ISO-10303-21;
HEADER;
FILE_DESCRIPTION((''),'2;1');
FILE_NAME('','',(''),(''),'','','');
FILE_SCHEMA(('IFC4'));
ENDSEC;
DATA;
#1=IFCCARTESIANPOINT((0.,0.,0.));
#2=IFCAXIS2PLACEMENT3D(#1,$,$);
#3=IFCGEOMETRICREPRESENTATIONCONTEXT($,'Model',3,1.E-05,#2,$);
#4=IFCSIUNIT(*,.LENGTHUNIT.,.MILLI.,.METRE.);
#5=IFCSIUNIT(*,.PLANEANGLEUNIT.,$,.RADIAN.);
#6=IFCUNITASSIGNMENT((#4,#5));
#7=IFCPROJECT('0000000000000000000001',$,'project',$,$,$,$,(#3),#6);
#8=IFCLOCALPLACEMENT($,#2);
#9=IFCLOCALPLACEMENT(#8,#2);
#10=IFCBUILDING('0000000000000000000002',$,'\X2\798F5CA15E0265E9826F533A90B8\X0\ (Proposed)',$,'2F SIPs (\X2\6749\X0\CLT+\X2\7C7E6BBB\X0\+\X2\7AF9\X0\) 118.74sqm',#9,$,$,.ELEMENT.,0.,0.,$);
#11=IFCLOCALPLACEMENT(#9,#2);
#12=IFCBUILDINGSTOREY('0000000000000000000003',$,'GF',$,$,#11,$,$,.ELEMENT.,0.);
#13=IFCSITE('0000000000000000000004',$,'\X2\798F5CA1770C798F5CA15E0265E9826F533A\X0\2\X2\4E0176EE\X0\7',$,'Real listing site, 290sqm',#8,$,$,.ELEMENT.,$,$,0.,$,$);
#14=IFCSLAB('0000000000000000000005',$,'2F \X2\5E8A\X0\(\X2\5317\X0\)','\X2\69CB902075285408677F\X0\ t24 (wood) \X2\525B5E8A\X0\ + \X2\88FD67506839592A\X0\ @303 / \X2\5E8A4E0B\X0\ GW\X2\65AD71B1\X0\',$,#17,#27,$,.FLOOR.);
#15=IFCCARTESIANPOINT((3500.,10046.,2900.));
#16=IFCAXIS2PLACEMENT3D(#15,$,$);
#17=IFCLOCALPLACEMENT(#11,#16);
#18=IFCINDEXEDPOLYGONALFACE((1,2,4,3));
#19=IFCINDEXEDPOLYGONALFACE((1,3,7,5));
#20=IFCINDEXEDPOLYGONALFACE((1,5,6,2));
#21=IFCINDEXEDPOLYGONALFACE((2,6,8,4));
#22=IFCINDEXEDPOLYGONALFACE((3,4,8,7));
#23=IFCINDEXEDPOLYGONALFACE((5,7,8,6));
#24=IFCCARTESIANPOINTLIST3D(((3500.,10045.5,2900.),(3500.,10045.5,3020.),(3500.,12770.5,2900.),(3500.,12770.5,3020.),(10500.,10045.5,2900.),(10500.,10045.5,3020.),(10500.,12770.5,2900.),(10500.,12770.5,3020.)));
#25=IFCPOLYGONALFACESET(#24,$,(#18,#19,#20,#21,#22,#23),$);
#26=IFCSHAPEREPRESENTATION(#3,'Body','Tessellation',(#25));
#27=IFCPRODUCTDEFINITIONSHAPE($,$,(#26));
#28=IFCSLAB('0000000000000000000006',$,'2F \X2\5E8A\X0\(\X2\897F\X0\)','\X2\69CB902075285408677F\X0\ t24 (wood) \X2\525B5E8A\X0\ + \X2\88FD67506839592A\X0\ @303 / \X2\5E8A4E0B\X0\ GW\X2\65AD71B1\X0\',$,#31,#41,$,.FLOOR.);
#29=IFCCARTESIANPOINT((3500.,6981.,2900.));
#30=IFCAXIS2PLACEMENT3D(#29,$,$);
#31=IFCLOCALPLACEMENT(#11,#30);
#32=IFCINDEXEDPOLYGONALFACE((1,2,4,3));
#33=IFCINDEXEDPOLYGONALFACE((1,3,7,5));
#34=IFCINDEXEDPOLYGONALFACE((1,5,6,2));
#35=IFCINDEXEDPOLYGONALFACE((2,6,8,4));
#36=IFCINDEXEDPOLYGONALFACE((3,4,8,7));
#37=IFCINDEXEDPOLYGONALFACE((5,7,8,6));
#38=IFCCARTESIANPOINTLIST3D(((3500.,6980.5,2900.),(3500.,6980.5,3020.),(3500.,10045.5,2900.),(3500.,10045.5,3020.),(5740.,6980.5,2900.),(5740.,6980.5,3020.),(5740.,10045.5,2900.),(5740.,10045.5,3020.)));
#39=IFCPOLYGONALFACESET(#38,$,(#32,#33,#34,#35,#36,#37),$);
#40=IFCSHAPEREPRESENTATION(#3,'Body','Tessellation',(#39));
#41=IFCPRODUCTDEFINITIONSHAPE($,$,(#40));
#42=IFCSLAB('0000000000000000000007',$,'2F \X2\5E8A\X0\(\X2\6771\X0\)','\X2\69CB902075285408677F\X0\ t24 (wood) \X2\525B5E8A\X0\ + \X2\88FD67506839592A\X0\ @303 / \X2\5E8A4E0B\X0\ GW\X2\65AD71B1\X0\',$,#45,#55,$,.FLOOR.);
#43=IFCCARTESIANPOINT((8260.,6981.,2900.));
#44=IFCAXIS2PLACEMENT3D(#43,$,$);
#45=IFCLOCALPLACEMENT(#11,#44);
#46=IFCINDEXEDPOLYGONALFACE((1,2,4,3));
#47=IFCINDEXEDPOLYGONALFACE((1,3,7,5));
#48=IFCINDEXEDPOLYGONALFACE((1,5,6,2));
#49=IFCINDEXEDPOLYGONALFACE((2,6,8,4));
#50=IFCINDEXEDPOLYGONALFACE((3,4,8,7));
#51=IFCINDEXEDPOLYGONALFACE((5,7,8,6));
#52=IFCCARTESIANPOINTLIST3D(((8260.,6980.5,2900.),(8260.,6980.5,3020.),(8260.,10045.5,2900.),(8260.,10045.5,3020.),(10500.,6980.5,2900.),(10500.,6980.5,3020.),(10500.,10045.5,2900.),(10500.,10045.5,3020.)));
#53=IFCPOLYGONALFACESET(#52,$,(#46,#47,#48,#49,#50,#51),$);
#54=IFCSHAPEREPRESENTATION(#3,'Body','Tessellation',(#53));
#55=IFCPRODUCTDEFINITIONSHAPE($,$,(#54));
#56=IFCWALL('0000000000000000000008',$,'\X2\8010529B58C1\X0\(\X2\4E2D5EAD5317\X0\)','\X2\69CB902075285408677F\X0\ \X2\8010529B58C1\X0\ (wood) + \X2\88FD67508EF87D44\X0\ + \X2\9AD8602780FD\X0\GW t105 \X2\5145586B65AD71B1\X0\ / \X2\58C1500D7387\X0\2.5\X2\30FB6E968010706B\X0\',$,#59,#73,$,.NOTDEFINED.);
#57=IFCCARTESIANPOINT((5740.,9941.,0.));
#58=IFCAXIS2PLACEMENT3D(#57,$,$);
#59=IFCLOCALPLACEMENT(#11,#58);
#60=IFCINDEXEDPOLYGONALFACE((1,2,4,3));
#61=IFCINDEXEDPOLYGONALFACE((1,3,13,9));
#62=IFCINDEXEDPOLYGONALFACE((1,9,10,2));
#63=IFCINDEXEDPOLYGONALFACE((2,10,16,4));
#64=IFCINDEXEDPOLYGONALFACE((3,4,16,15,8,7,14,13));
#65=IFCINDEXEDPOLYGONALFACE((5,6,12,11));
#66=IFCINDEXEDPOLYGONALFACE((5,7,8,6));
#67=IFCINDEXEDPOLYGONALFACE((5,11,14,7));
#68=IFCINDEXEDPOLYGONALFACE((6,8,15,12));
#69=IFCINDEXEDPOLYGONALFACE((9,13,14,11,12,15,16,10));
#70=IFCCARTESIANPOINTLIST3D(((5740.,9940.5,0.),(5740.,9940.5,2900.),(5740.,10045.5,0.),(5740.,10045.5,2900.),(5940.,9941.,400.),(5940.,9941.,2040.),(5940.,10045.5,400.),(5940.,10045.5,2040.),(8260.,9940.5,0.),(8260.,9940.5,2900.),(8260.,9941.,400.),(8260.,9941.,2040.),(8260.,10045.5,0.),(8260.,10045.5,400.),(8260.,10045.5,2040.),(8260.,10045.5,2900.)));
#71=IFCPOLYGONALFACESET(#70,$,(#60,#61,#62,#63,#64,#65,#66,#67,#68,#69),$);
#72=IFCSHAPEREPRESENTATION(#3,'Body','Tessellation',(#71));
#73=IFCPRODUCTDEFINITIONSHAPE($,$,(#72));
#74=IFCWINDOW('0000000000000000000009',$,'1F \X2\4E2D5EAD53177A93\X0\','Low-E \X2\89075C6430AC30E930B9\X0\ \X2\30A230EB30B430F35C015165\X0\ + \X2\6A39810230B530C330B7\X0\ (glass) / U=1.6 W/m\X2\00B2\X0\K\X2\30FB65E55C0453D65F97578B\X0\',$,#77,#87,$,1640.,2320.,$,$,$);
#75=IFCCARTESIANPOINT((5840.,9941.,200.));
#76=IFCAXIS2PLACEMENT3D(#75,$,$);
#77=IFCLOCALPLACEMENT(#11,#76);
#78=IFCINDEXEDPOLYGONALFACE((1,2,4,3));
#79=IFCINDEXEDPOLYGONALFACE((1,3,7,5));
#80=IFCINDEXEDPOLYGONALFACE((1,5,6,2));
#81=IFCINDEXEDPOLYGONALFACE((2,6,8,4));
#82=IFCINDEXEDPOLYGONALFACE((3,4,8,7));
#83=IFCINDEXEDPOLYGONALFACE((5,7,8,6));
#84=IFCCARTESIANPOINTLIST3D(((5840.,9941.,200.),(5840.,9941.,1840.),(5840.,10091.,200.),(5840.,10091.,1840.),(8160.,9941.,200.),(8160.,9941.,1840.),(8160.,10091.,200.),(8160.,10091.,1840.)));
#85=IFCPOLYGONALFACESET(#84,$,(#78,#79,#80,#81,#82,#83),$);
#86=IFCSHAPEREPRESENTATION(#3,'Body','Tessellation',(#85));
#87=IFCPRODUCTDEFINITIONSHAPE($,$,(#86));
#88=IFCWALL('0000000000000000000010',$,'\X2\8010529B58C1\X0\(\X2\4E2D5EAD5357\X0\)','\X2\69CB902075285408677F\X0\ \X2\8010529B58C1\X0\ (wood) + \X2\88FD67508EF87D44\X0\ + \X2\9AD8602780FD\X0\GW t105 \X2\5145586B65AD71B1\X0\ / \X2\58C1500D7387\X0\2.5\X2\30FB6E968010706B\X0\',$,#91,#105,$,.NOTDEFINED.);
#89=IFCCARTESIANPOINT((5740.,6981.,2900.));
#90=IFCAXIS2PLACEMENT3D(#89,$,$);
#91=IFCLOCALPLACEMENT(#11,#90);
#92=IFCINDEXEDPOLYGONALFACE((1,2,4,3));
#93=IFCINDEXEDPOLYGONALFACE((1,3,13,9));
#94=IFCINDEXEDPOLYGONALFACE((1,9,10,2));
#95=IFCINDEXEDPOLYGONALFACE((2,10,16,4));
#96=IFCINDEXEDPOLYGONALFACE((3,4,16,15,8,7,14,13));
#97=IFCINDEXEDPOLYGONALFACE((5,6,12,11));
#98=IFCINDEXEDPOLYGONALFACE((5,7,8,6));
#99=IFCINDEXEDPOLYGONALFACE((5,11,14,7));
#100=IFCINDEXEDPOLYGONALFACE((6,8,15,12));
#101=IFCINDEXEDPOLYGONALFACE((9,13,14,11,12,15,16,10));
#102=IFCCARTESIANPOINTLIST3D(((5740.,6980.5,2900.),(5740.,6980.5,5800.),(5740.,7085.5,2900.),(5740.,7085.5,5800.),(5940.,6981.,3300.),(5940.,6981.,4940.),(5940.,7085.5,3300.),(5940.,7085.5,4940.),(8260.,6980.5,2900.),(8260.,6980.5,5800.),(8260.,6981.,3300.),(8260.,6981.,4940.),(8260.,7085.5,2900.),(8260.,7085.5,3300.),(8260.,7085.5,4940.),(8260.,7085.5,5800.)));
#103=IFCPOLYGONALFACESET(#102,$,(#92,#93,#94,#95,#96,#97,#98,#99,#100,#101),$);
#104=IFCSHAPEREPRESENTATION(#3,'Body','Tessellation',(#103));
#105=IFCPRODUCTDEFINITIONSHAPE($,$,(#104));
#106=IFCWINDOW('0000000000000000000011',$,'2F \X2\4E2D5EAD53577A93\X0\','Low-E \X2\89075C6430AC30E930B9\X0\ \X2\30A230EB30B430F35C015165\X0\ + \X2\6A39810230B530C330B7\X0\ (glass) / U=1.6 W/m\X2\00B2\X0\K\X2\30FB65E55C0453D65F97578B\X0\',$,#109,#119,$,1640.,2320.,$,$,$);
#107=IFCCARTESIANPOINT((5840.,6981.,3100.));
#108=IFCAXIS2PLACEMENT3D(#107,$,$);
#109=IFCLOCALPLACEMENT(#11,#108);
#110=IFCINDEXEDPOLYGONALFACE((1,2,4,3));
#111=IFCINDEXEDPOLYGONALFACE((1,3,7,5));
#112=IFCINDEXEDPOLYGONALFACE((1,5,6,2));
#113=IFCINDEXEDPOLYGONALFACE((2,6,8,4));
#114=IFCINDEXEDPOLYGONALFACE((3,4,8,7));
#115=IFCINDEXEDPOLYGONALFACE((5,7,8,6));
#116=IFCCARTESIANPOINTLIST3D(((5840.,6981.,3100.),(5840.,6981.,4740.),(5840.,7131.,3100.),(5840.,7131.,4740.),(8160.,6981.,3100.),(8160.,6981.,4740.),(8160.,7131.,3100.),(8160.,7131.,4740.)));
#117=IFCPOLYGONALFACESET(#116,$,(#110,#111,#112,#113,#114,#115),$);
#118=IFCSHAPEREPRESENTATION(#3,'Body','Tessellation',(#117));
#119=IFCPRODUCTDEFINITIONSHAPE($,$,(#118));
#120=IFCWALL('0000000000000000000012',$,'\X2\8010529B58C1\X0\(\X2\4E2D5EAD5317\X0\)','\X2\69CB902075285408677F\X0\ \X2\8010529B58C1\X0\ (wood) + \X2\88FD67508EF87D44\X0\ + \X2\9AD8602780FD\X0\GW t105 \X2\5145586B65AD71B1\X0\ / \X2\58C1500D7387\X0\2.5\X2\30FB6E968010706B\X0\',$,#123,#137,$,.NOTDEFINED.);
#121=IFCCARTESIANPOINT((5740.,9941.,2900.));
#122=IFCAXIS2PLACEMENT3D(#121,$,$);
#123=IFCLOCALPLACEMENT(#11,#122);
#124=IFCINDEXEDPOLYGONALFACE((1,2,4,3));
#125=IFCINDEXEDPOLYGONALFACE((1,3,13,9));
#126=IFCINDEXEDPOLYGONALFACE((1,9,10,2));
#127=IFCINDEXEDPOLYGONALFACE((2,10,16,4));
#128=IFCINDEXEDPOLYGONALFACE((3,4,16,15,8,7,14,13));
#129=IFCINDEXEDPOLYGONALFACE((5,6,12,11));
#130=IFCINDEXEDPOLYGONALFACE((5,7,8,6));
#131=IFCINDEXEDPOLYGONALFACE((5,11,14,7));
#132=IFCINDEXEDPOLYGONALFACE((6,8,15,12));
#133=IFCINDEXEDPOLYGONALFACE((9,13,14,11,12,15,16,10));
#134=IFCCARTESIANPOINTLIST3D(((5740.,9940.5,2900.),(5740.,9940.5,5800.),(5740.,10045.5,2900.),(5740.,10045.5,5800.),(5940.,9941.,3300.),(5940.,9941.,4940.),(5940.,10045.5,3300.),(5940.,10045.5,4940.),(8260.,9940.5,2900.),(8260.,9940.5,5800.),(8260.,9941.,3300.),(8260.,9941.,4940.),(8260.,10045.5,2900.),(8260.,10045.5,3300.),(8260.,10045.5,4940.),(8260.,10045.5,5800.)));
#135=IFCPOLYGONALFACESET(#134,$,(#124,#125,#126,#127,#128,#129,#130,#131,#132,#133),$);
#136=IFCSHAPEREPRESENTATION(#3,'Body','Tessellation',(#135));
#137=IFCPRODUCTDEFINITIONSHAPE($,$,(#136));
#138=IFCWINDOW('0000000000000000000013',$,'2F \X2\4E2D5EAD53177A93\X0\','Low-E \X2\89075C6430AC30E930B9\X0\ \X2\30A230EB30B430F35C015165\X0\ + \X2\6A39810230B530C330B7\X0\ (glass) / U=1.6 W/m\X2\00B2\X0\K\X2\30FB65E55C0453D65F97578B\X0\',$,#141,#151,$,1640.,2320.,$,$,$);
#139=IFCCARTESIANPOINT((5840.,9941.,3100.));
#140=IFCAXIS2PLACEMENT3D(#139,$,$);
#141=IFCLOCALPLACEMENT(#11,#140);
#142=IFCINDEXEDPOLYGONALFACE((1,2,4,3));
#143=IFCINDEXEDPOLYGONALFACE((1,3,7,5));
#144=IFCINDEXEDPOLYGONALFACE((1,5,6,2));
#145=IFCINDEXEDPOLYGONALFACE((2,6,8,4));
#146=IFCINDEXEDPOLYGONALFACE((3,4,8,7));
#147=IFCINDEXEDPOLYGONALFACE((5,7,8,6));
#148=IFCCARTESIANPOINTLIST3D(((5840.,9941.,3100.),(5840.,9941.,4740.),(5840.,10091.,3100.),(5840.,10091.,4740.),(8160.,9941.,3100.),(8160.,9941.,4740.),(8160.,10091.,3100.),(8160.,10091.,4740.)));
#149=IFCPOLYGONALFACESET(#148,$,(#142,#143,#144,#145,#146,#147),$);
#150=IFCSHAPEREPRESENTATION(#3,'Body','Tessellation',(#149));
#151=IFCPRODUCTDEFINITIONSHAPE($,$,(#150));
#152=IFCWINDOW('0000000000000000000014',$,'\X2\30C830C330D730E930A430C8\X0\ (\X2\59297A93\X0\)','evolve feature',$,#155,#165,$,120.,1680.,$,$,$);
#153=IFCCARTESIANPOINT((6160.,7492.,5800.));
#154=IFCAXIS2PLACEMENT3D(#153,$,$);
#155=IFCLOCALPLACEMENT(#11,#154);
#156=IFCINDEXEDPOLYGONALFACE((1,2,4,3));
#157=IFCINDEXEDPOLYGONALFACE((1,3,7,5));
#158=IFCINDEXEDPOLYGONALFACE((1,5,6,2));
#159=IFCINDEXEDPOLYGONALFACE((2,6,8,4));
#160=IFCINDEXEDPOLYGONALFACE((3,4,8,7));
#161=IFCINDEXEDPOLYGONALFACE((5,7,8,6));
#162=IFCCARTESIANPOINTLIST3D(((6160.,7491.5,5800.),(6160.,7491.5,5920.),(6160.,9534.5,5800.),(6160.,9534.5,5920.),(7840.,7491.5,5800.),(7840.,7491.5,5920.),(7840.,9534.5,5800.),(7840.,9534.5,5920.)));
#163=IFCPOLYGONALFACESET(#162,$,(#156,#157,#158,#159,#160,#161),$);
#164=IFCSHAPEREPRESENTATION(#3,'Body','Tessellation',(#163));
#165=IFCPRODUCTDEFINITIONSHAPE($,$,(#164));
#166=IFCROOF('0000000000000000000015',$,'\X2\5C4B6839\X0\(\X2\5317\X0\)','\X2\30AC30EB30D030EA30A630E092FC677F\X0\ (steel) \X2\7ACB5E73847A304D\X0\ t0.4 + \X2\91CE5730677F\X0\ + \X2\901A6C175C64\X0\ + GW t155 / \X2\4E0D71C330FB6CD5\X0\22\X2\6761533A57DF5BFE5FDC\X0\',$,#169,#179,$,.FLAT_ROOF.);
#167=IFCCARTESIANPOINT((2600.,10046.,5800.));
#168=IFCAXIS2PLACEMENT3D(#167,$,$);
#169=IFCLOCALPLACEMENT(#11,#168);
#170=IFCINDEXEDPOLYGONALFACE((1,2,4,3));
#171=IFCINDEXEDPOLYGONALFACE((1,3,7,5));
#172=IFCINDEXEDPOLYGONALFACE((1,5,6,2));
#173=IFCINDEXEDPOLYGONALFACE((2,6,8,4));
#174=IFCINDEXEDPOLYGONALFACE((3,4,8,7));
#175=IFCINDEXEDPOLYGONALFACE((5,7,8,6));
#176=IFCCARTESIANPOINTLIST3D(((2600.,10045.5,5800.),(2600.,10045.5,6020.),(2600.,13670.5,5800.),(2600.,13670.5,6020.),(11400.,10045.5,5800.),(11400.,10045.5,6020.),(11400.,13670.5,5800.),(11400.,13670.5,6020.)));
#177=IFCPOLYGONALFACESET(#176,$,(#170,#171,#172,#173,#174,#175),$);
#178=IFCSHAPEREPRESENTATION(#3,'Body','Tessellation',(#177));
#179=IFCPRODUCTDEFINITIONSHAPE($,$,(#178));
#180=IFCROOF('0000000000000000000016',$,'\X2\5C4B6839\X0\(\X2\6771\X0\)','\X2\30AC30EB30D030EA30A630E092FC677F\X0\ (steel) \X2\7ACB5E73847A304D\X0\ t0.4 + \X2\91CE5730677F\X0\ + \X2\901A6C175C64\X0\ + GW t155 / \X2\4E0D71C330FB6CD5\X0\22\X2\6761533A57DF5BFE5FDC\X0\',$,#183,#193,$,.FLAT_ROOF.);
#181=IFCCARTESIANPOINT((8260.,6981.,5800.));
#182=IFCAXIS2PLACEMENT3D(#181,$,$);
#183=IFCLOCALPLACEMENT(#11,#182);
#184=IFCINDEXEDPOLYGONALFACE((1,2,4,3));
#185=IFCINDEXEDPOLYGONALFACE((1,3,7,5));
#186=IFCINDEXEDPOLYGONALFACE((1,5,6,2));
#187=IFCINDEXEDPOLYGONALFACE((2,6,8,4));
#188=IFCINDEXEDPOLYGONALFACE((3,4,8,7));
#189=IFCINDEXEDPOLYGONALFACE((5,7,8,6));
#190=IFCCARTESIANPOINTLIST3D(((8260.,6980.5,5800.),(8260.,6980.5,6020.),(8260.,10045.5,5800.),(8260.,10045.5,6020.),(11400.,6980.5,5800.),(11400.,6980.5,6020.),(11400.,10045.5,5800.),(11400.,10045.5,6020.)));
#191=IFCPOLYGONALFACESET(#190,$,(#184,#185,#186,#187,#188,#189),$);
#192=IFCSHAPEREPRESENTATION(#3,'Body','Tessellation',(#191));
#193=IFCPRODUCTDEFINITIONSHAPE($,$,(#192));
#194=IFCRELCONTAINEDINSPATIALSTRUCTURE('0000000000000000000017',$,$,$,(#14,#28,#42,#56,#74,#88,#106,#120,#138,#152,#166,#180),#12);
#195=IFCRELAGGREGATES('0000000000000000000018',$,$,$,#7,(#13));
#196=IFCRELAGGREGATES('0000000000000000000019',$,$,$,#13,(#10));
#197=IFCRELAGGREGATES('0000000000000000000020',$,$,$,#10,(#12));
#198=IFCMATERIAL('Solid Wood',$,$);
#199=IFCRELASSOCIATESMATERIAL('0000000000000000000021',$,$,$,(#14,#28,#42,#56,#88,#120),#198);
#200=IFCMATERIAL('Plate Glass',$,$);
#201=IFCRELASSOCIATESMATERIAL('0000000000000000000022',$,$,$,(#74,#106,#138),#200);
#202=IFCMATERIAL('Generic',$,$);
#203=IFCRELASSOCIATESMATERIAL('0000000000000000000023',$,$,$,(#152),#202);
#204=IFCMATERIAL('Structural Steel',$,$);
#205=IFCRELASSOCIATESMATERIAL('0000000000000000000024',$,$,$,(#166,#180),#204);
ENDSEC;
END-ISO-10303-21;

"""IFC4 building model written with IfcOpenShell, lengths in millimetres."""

from ifc_helpers import new_model, si_unit, frame, frame_2d, origin, place, context, project, spatial, rectangle, extrude, material, element, fill, save


model = new_model("IFC4")

# Units and contexts
model_context = context("Model", 3, precision=1e-05, world=origin())
ifc_project = project(units=[si_unit("LENGTHUNIT", "METRE", prefix="MILLI"), si_unit("PLANEANGLEUNIT", "RADIAN")], contexts=[model_context])

# Site, building, storey
site_placement = place(None, origin())
site = spatial("IfcSite", under=ifc_project, at=site_placement, Name="福岡県福岡市早良区2丁目7", ObjectType="Real listing site, 290sqm", CompositionType="ELEMENT", RefElevation=0.0)
building_placement = place(site_placement, origin())
building = spatial("IfcBuilding", under=site, at=building_placement, Name="福岡市早良区邸 (Proposed)", ObjectType="2F SIPs (杉CLT+籾殻+竹) 118.74sqm", CompositionType="ELEMENT", ElevationOfRefHeight=0.0, ElevationOfTerrain=0.0)
storey_placement = place(building_placement, origin())
storey = spatial("IfcBuildingStorey", under=building, at=storey_placement, Name="GF", CompositionType="ELEMENT", Elevation=0.0)

# Slabs
ifc_material_1 = material(Name="Solid Wood")
slab_1_placement = place(storey_placement, frame((3500.0, 10046.0, 2900.0)))
element("IfcSlab", 1, at=slab_1_placement, inside=storey, material=ifc_material_1, Name="2F 床(北)", Description="構造用合板 t24 (wood) 剛床 + 製材根太 @303 / 床下 GW断熱", PredefinedType="FLOOR", context=model_context, shape_type="SweptSolid", body=[
    extrude(rectangle(XDim=7000.0, YDim=2725.0, at=frame_2d((3500.0, 1362.0))), frame((3500.0, 10046.0, 2900.0)), (0.0, 0.0, 1.0), 120.0),
])
slab_2_placement = place(storey_placement, frame((3500.0, 6981.0, 2900.0)))
element("IfcSlab", 2, at=slab_2_placement, inside=storey, material=ifc_material_1, Name="2F 床(西)", Description="構造用合板 t24 (wood) 剛床 + 製材根太 @303 / 床下 GW断熱", PredefinedType="FLOOR", context=model_context, shape_type="SweptSolid", body=[
    extrude(rectangle(XDim=2240.0, YDim=3065.0, at=frame_2d((1120.0, 1532.0))), frame((3500.0, 6981.0, 2900.0)), (0.0, 0.0, 1.0), 120.0),
])
slab_3_placement = place(storey_placement, frame((8260.0, 6981.0, 2900.0)))
element("IfcSlab", 3, at=slab_3_placement, inside=storey, material=ifc_material_1, Name="2F 床(東)", Description="構造用合板 t24 (wood) 剛床 + 製材根太 @303 / 床下 GW断熱", PredefinedType="FLOOR", context=model_context, shape_type="SweptSolid", body=[
    extrude(rectangle(XDim=2240.0, YDim=3065.0, at=frame_2d((1120.0, 1532.0))), frame((8260.0, 6981.0, 2900.0)), (0.0, 0.0, 1.0), 120.0),
])

# Wall, opening, window
wall_1_placement = place(storey_placement, frame((5740.0, 9941.0, 0.0)))
wall_1 = element("IfcWall", 4, at=wall_1_placement, inside=storey, material=ifc_material_1, Name="耐力壁(中庭北)", Description="構造用合板 耐力壁 (wood) + 製材軸組 + 高性能GW t105 充填断熱 / 壁倍率2.5・準耐火", PredefinedType="NOTDEFINED", context=model_context, shape_type="SweptSolid", body=[
    extrude(rectangle(XDim=2520.0, YDim=105.0, at=frame_2d((1260.0, 52.0))), frame((5740.0, 9941.0, 0.0)), (0.0, 0.0, 1.0), 2900.0),
])
opening_1_placement = place(storey_placement, frame((5840.0, 9941.0, 200.0)))
opening_1 = element("IfcOpeningElement", 5, at=opening_1_placement, cuts=wall_1, PredefinedType="NOTDEFINED", context=model_context, shape_type="SweptSolid", body=[
    extrude(rectangle(XDim=2320.0, YDim=150.0, at=frame_2d((1160.0, 75.0))), frame((5840.0, 9941.0, 200.0)), (0.0, 0.0, 1.0), 1640.0),
])
ifc_material_2 = material(Name="Plate Glass")
window_1_placement = place(storey_placement, frame((5840.0, 9941.0, 200.0)))
window_1 = element("IfcWindow", 6, at=window_1_placement, inside=storey, material=ifc_material_2, Name="1F 中庭北窓", Description="Low-E 複層ガラス アルゴン封入 + 樹脂サッシ (glass) / U=1.6 W/m²K・日射取得型", OverallHeight=1640.0, OverallWidth=2320.0, context=model_context, shape_type="SweptSolid", body=[
    extrude(rectangle(XDim=2320.0, YDim=150.0, at=frame_2d((1160.0, 75.0))), frame((5840.0, 9941.0, 200.0)), (0.0, 0.0, 1.0), 1640.0),
])
fill(opening_1, window_1)

# Walls, openings, windows
wall_2_placement = place(storey_placement, frame((5740.0, 6981.0, 2900.0)))
wall_2 = element("IfcWall", 7, at=wall_2_placement, inside=storey, material=ifc_material_1, Name="耐力壁(中庭南)", Description="構造用合板 耐力壁 (wood) + 製材軸組 + 高性能GW t105 充填断熱 / 壁倍率2.5・準耐火", PredefinedType="NOTDEFINED", context=model_context, shape_type="SweptSolid", body=[
    extrude(rectangle(XDim=2520.0, YDim=105.0, at=frame_2d((1260.0, 52.0))), frame((5740.0, 6981.0, 2900.0)), (0.0, 0.0, 1.0), 2900.0),
])
opening_2_placement = place(storey_placement, frame((5840.0, 6981.0, 3100.0)))
opening_2 = element("IfcOpeningElement", 8, at=opening_2_placement, cuts=wall_2, PredefinedType="NOTDEFINED", context=model_context, shape_type="SweptSolid", body=[
    extrude(rectangle(XDim=2320.0, YDim=150.0, at=frame_2d((1160.0, 75.0))), frame((5840.0, 6981.0, 3100.0)), (0.0, 0.0, 1.0), 1640.0),
])
window_2_placement = place(storey_placement, frame((5840.0, 6981.0, 3100.0)))
window_2 = element("IfcWindow", 9, at=window_2_placement, inside=storey, material=ifc_material_2, Name="2F 中庭南窓", Description="Low-E 複層ガラス アルゴン封入 + 樹脂サッシ (glass) / U=1.6 W/m²K・日射取得型", OverallHeight=1640.0, OverallWidth=2320.0, context=model_context, shape_type="SweptSolid", body=[
    extrude(rectangle(XDim=2320.0, YDim=150.0, at=frame_2d((1160.0, 75.0))), frame((5840.0, 6981.0, 3100.0)), (0.0, 0.0, 1.0), 1640.0),
])
fill(opening_2, window_2)
wall_3_placement = place(storey_placement, frame((5740.0, 9941.0, 2900.0)))
wall_3 = element("IfcWall", 10, at=wall_3_placement, inside=storey, material=ifc_material_1, Name="耐力壁(中庭北)", Description="構造用合板 耐力壁 (wood) + 製材軸組 + 高性能GW t105 充填断熱 / 壁倍率2.5・準耐火", PredefinedType="NOTDEFINED", context=model_context, shape_type="SweptSolid", body=[
    extrude(rectangle(XDim=2520.0, YDim=105.0, at=frame_2d((1260.0, 52.0))), frame((5740.0, 9941.0, 2900.0)), (0.0, 0.0, 1.0), 2900.0),
])
opening_3_placement = place(storey_placement, frame((5840.0, 9941.0, 3100.0)))
opening_3 = element("IfcOpeningElement", 11, at=opening_3_placement, cuts=wall_3, PredefinedType="NOTDEFINED", context=model_context, shape_type="SweptSolid", body=[
    extrude(rectangle(XDim=2320.0, YDim=150.0, at=frame_2d((1160.0, 75.0))), frame((5840.0, 9941.0, 3100.0)), (0.0, 0.0, 1.0), 1640.0),
])
window_3_placement = place(storey_placement, frame((5840.0, 9941.0, 3100.0)))
window_3 = element("IfcWindow", 12, at=window_3_placement, inside=storey, material=ifc_material_2, Name="2F 中庭北窓", Description="Low-E 複層ガラス アルゴン封入 + 樹脂サッシ (glass) / U=1.6 W/m²K・日射取得型", OverallHeight=1640.0, OverallWidth=2320.0, context=model_context, shape_type="SweptSolid", body=[
    extrude(rectangle(XDim=2320.0, YDim=150.0, at=frame_2d((1160.0, 75.0))), frame((5840.0, 9941.0, 3100.0)), (0.0, 0.0, 1.0), 1640.0),
])
fill(opening_3, window_3)

# Window
ifc_material_3 = material(Name="Generic")
window_4_placement = place(storey_placement, frame((6160.0, 7492.0, 5800.0)))
element("IfcWindow", 13, at=window_4_placement, inside=storey, material=ifc_material_3, Name="トップライト (天窓)", Description="evolve feature", OverallHeight=120.0, OverallWidth=1680.0, context=model_context, shape_type="SweptSolid", body=[
    extrude(rectangle(XDim=1680.0, YDim=2043.0, at=frame_2d((840.0, 1021.0))), frame((6160.0, 7492.0, 5800.0)), (0.0, 0.0, 1.0), 120.0),
])

# Roofs
ifc_material_4 = material(Name="Structural Steel")
roof_1_placement = place(storey_placement, frame((2600.0, 10046.0, 5800.0)))
element("IfcRoof", 14, at=roof_1_placement, inside=storey, material=ifc_material_4, Name="屋根(北)", Description="ガルバリウム鋼板 (steel) 立平葺き t0.4 + 野地板 + 通気層 + GW t155 / 不燃・法22条区域対応", PredefinedType="FLAT_ROOF", context=model_context, shape_type="SweptSolid", body=[
    extrude(rectangle(XDim=8800.0, YDim=3625.0, at=frame_2d((4400.0, 1812.0))), frame((2600.0, 10046.0, 5800.0)), (0.0, 0.0, 1.0), 220.0),
])
roof_2_placement = place(storey_placement, frame((8260.0, 6981.0, 5800.0)))
element("IfcRoof", 15, at=roof_2_placement, inside=storey, material=ifc_material_4, Name="屋根(東)", Description="ガルバリウム鋼板 (steel) 立平葺き t0.4 + 野地板 + 通気層 + GW t155 / 不燃・法22条区域対応", PredefinedType="FLAT_ROOF", context=model_context, shape_type="SweptSolid", body=[
    extrude(rectangle(XDim=3140.0, YDim=3065.0, at=frame_2d((1570.0, 1532.0))), frame((8260.0, 6981.0, 5800.0)), (0.0, 0.0, 1.0), 220.0),
])

save(model, "model.ifc")
